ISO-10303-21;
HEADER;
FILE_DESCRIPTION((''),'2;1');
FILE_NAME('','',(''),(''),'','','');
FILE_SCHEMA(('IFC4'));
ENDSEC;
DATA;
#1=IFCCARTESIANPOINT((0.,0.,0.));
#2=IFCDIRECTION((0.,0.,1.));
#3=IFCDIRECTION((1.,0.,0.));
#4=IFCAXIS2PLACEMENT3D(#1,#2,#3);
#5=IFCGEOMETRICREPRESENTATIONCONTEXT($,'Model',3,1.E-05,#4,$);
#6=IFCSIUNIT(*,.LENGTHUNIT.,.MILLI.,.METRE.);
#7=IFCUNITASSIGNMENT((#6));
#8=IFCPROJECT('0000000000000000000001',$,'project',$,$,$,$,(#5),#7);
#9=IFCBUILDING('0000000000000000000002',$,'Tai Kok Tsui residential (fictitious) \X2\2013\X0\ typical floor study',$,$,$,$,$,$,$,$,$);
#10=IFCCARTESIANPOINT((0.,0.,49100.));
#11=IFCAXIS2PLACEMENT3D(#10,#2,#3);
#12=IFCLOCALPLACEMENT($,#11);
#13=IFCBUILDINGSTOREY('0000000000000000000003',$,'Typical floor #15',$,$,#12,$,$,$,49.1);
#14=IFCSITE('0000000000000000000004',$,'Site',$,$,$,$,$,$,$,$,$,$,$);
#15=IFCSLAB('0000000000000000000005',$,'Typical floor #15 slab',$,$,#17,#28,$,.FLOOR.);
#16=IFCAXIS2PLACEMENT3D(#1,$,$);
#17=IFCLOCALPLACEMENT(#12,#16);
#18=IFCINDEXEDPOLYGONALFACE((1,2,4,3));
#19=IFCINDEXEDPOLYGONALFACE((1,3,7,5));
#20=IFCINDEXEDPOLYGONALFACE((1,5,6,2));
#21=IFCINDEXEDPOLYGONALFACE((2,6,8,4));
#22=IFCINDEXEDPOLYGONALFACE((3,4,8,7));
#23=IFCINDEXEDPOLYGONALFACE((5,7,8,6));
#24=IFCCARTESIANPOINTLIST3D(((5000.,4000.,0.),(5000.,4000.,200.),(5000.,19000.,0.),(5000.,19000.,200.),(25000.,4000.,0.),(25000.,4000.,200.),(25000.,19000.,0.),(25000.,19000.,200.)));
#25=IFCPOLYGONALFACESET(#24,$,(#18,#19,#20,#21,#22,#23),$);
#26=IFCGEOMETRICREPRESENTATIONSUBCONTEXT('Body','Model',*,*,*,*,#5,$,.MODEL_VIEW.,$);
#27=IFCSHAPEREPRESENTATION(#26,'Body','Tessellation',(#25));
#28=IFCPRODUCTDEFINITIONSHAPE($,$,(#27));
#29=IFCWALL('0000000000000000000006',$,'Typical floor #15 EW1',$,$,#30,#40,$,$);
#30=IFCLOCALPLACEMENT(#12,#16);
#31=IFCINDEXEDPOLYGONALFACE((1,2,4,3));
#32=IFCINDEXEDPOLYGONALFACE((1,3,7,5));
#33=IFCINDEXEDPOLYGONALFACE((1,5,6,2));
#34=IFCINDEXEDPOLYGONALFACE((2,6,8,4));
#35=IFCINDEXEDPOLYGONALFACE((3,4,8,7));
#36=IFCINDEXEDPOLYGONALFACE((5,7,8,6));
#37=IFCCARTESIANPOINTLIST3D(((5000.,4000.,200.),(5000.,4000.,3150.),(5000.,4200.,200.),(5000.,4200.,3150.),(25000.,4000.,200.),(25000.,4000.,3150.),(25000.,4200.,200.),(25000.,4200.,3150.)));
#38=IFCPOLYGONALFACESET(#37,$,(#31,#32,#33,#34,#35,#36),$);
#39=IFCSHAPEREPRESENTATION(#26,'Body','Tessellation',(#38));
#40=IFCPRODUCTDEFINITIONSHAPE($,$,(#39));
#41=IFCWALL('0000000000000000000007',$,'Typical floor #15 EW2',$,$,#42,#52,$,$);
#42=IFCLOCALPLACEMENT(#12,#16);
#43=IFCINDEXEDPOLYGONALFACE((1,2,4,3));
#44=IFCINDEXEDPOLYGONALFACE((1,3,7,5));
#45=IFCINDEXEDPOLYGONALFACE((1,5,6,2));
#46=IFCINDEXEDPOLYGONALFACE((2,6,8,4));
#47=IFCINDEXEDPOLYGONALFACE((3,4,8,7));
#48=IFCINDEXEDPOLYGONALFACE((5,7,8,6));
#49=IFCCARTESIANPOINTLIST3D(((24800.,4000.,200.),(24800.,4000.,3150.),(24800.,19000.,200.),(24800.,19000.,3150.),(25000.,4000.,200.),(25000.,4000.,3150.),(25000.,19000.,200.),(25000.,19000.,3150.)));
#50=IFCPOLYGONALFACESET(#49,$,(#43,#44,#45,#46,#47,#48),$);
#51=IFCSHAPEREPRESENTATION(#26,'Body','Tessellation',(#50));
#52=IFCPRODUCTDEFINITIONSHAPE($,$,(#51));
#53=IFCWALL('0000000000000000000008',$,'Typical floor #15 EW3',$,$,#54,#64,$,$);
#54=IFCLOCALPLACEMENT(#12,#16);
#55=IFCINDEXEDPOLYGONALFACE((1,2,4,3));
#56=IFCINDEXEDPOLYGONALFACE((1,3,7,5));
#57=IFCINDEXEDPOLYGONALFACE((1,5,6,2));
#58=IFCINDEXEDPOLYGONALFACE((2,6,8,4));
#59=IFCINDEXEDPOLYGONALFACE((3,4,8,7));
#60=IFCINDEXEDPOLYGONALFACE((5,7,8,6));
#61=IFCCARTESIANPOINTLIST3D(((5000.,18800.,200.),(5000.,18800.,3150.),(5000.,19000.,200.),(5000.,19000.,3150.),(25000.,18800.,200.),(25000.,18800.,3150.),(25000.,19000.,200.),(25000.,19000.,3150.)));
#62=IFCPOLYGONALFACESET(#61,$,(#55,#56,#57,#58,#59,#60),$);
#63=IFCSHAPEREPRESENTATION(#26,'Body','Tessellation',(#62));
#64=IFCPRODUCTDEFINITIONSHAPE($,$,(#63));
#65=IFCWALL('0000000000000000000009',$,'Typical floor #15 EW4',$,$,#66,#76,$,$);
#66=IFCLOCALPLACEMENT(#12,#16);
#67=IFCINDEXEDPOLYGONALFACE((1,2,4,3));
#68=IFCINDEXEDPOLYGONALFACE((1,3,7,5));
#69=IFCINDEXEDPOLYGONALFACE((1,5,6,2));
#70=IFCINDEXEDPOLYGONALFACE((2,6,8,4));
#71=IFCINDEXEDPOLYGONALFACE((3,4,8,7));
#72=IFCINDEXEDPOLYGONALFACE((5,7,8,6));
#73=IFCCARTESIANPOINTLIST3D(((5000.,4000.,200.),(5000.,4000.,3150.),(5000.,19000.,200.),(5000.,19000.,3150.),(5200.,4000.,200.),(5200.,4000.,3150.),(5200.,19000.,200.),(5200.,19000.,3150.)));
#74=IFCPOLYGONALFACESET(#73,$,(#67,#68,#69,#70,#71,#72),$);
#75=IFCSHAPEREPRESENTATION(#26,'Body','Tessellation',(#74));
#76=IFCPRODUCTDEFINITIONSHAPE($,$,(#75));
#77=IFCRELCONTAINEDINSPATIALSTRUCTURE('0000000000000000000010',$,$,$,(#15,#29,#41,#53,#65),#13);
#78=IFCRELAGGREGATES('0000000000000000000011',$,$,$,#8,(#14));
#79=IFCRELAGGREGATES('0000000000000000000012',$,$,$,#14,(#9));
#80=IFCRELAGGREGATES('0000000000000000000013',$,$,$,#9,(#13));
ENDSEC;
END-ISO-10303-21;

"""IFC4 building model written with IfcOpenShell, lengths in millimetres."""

from ifc_helpers import new_model, si_unit, frame, origin_with_axes, place, context, subcontext, project, spatial, indexed_curve, outline, extrude, element, save


model = new_model("IFC4")

# Units and contexts
model_context = context("Model", 3, precision=1e-05, world=origin_with_axes())
body_context = subcontext(model_context, "Body", "Model", "MODEL_VIEW")
ifc_project = project(units=[si_unit("LENGTHUNIT", "METRE", prefix="MILLI")], contexts=[model_context])

# Site, building, storey
site = spatial("IfcSite", under=ifc_project, Name="Site")
building = spatial("IfcBuilding", under=site, Name="Tai Kok Tsui residential (fictitious) – typical floor study")
storey_placement = place(None, frame((0.0, 0.0, 49100.0), z_axis=(0.0, 0.0, 1.0), x_axis=(1.0, 0.0, 0.0)))
storey = spatial("IfcBuildingStorey", under=building, at=storey_placement, Name="Typical floor #15", Elevation=49.1)

# Slab
slab_placement = place(storey_placement, origin_with_axes())
element("IfcSlab", 1, at=slab_placement, inside=storey, Name="Typical floor #15 slab", PredefinedType="FLOOR", context=body_context, shape_type="SweptSolid", body=[
    extrude(outline(indexed_curve([(5000.0, 4000.0), (25000.0, 4000.0), (25000.0, 19000.0), (5000.0, 19000.0)])), None, (0.0, 0.0, 1.0), 200.0),
])

# Walls
wall_1_placement = place(storey_placement, frame((5000.0, 4000.0, 200.0), z_axis=(0.0, 0.0, 1.0), x_axis=(1.0, 0.0, 0.0)))
element("IfcWall", 2, at=wall_1_placement, inside=storey, Name="Typical floor #15 EW1", context=body_context, shape_type="SweptSolid", body=[
    extrude(outline(indexed_curve([(0.0, 0.0), (0.0, 200.0), (20000.0, 200.0), (20000.0, 0.0), (0.0, 0.0)], self_intersect=False)), origin_with_axes(), (0.0, 0.0, 1.0), 2950.0),
])
wall_2_placement = place(storey_placement, frame((25000.0, 4000.0, 200.0), z_axis=(0.0, 0.0, 1.0), x_axis=(0.0, 1.0, 0.0)))
element("IfcWall", 3, at=wall_2_placement, inside=storey, Name="Typical floor #15 EW2", context=body_context, shape_type="SweptSolid", body=[
    extrude(outline(indexed_curve([(0.0, 0.0), (0.0, 200.0), (15000.0, 200.0), (15000.0, 0.0), (0.0, 0.0)], self_intersect=False)), origin_with_axes(), (0.0, 0.0, 1.0), 2950.0),
])
wall_3_placement = place(storey_placement, frame((25000.0, 19000.0, 200.0), z_axis=(0.0, 0.0, 1.0), x_axis=(-1.0, 0.0, 0.0)))
element("IfcWall", 4, at=wall_3_placement, inside=storey, Name="Typical floor #15 EW3", context=body_context, shape_type="SweptSolid", body=[
    extrude(outline(indexed_curve([(0.0, 0.0), (0.0, 200.0), (20000.0, 200.0), (20000.0, 0.0), (0.0, 0.0)], self_intersect=False)), origin_with_axes(), (0.0, 0.0, 1.0), 2950.0),
])
wall_4_placement = place(storey_placement, frame((5000.0, 19000.0, 200.0), z_axis=(0.0, 0.0, 1.0), x_axis=(0.0, -1.0, 0.0)))
element("IfcWall", 5, at=wall_4_placement, inside=storey, Name="Typical floor #15 EW4", context=body_context, shape_type="SweptSolid", body=[
    extrude(outline(indexed_curve([(0.0, 0.0), (0.0, 200.0), (15000.0, 200.0), (15000.0, 0.0), (0.0, 0.0)], self_intersect=False)), origin_with_axes(), (0.0, 0.0, 1.0), 2950.0),
])

save(model, "model.ifc")
